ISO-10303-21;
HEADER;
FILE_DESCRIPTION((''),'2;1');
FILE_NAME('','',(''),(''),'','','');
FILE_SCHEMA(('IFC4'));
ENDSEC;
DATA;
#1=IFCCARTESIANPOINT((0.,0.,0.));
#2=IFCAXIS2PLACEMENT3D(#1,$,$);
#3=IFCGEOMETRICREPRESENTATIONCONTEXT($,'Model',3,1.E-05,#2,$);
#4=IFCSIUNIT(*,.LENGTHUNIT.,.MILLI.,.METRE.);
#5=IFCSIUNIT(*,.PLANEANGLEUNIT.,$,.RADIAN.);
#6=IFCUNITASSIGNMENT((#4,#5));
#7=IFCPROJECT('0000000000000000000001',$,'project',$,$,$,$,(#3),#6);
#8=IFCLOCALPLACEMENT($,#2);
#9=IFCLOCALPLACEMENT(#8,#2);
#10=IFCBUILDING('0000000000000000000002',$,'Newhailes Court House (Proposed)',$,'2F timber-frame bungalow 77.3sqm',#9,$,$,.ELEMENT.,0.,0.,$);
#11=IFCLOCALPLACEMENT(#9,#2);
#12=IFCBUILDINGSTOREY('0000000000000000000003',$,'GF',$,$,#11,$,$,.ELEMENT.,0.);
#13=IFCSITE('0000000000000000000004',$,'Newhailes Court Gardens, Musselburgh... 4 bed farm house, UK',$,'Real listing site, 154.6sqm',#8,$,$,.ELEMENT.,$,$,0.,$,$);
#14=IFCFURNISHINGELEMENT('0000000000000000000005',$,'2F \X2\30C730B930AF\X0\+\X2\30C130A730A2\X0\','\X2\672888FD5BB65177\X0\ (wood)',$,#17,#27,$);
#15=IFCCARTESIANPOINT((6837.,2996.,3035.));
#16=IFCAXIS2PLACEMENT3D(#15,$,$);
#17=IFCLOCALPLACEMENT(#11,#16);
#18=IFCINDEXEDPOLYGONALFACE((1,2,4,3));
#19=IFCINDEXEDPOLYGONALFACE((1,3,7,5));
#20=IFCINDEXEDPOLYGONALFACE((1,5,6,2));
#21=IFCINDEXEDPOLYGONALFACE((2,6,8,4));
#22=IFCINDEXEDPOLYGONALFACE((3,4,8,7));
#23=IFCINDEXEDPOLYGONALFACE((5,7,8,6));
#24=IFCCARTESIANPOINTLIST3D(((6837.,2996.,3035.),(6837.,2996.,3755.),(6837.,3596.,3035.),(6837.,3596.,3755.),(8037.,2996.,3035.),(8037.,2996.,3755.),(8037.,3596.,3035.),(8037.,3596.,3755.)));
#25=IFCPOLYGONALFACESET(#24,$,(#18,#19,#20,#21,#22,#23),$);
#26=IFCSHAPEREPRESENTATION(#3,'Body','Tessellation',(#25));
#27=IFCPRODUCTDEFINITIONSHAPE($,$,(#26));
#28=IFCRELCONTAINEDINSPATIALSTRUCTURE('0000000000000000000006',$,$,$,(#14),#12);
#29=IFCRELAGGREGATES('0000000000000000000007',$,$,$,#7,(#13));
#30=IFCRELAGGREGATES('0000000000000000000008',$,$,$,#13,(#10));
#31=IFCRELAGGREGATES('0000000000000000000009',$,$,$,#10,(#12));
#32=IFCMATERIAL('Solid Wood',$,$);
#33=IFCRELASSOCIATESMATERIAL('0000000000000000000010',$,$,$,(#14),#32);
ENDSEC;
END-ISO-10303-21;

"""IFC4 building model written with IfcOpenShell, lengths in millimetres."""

from ifc_helpers import new_model, si_unit, frame, frame_2d, origin, place, context, project, spatial, rectangle, extrude, material, element, save


model = new_model("IFC4")

# Units and contexts
model_context = context("Model", 3, precision=1e-05, world=origin())
ifc_project = project(units=[si_unit("LENGTHUNIT", "METRE", prefix="MILLI"), si_unit("PLANEANGLEUNIT", "RADIAN")], contexts=[model_context])

# Site, building, storey
site_placement = place(None, origin())
site = spatial("IfcSite", under=ifc_project, at=site_placement, Name="Newhailes Court Gardens, Musselburgh... 4 bed farm house, UK", ObjectType="Real listing site, 154.6sqm", CompositionType="ELEMENT", RefElevation=0.0)
building_placement = place(site_placement, origin())
building = spatial("IfcBuilding", under=site, at=building_placement, Name="Newhailes Court House (Proposed)", ObjectType="2F timber-frame bungalow 77.3sqm", CompositionType="ELEMENT", ElevationOfRefHeight=0.0, ElevationOfTerrain=0.0)
storey_placement = place(building_placement, origin())
storey = spatial("IfcBuildingStorey", under=building, at=storey_placement, Name="GF", CompositionType="ELEMENT", Elevation=0.0)

# Shared definitions
ifc_material_1 = material(Name="Solid Wood")

# Furnishing element
furnishing_1_placement = place(storey_placement, frame((6837.0, 2996.0, 3035.0)))
element("IfcFurnishingElement", 1, at=furnishing_1_placement, inside=storey, material=ifc_material_1, Name="2F デスク+チェア", Description="木製家具 (wood)", context=model_context, shape_type="SweptSolid", body=[
    extrude(rectangle(XDim=1200.0, YDim=600.0, at=frame_2d((600.0, 300.0))), frame((6837.0, 2996.0, 3035.0)), (0.0, 0.0, 1.0), 720.0),
])

save(model, "model.ifc")
